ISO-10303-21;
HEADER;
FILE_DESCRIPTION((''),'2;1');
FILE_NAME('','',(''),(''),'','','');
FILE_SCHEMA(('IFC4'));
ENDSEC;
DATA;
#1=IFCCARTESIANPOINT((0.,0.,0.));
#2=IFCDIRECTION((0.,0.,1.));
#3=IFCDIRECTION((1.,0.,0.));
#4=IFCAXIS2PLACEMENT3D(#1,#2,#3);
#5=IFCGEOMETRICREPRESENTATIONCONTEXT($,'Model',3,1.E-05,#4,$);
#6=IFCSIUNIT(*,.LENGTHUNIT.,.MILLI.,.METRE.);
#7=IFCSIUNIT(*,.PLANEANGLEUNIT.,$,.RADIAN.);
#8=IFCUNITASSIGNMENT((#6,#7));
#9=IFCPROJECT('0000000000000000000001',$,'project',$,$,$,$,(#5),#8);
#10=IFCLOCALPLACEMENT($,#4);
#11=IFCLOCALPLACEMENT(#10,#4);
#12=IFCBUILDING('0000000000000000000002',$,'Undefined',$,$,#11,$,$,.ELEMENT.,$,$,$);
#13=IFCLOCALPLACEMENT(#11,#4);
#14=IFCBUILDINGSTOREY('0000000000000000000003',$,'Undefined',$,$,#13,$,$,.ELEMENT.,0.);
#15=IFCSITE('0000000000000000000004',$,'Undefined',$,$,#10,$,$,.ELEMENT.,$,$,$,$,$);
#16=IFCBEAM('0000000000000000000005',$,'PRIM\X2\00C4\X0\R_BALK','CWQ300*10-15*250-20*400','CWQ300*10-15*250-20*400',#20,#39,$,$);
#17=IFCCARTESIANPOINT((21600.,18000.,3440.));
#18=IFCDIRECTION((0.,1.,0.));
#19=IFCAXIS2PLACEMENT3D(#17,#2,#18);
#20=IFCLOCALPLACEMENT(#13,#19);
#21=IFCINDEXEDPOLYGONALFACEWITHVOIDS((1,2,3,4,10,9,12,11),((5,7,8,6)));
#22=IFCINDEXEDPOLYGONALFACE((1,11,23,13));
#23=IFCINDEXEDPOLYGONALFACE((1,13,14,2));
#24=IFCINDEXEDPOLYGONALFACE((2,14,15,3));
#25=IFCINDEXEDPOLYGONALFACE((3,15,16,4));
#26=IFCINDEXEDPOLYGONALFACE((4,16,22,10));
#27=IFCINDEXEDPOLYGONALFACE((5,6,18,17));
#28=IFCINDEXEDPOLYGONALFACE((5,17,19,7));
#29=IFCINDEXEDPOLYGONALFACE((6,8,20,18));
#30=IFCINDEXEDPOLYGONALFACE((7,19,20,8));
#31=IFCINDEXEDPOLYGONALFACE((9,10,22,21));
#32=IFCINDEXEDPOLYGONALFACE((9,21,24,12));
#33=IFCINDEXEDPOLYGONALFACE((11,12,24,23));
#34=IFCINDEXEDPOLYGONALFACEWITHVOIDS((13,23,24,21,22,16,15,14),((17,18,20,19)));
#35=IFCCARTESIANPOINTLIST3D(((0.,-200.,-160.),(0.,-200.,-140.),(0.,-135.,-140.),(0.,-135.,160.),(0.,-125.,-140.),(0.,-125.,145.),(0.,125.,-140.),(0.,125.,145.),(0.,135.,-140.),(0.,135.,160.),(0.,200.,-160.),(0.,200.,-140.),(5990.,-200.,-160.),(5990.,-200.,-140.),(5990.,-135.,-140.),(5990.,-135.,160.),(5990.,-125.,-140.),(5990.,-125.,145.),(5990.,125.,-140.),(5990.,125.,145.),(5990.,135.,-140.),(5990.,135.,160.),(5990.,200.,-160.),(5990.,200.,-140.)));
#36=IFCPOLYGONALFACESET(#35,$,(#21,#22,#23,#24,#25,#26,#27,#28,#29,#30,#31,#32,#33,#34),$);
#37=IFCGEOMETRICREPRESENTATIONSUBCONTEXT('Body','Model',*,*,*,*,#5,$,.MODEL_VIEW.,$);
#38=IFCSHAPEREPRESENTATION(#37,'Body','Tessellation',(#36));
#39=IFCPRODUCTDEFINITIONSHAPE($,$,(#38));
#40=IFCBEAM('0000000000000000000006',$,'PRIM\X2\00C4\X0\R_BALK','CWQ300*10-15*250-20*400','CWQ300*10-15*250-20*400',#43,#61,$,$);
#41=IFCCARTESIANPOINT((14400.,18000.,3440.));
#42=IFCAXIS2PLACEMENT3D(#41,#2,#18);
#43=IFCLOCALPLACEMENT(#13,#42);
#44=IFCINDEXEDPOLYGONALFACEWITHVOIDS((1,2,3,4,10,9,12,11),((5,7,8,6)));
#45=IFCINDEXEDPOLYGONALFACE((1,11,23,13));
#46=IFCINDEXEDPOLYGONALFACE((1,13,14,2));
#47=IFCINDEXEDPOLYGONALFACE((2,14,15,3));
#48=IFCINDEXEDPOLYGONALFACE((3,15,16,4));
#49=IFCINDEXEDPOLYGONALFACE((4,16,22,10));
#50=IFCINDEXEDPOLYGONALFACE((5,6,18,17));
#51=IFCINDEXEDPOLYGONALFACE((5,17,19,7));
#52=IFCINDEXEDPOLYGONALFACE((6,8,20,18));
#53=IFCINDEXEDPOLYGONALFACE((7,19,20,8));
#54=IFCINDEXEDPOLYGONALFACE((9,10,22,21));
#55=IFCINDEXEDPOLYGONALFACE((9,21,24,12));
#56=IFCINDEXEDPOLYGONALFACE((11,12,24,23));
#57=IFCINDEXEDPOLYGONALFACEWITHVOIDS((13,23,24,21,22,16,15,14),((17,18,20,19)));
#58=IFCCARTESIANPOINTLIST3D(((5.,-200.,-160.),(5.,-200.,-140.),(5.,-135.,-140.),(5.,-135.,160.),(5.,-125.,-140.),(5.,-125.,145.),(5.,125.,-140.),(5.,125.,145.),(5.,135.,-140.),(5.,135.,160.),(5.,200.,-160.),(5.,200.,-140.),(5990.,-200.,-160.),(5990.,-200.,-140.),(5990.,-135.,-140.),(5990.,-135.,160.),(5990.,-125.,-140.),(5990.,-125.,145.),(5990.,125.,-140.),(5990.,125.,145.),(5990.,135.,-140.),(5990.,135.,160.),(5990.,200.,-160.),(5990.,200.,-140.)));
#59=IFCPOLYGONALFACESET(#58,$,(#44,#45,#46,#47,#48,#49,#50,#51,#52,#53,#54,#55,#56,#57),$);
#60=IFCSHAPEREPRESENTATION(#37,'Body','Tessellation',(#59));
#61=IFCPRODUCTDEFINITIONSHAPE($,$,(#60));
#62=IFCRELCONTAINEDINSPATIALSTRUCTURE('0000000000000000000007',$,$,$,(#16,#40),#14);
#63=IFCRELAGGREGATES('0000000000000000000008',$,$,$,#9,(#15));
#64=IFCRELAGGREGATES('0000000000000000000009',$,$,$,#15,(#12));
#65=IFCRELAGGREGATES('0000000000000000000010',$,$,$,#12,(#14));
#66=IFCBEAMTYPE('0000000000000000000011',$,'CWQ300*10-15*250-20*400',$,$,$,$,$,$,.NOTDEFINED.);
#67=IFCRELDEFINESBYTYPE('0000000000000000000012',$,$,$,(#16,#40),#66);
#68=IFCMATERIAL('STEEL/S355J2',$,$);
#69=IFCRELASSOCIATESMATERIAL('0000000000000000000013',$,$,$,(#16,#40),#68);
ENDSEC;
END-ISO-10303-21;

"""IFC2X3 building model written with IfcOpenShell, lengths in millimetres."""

from ifc_helpers import new_model, si_unit, frame, origin_with_axes, place, context, subcontext, project, spatial, polyline, outline, extrude, clip, halfspace, material, type_object, element, save


model = new_model("IFC2X3")

# Units and contexts
model_context = context("Model", 3, precision=1e-05, world=origin_with_axes())
body_context = subcontext(model_context, "Body", "Model", "MODEL_VIEW")
ifc_project = project(units=[si_unit("LENGTHUNIT", "METRE", prefix="MILLI"), si_unit("PLANEANGLEUNIT", "RADIAN")], contexts=[model_context])

# Site, building, storey
site_placement = place(None, origin_with_axes())
site = spatial("IfcSite", under=ifc_project, at=site_placement, Name="Undefined", CompositionType="ELEMENT")
building_placement = place(site_placement, origin_with_axes())
building = spatial("IfcBuilding", under=site, at=building_placement, Name="Undefined", CompositionType="ELEMENT")
storey_placement = place(building_placement, origin_with_axes())
storey = spatial("IfcBuildingStorey", under=building, at=storey_placement, Name="Undefined", CompositionType="ELEMENT", Elevation=0.0)

# Shared definitions
ifc_material_1 = material(Name="STEEL/S355J2")

# Beams
beam_type_1 = type_object("IfcBeamType", Name="CWQ300*10-15*250-20*400", PredefinedType="NOTDEFINED")
beam_1_placement = place(storey_placement, frame((21600.0, 18000.0, 3440.0), z_axis=(0.0, 0.0, 1.0), x_axis=(0.0, 1.0, 0.0)))
element("IfcBeam", 1, at=beam_1_placement, inside=storey, type_object=beam_type_1, material=ifc_material_1, Name="PRIMÄR_BALK", Description="CWQ300*10-15*250-20*400", ObjectType="CWQ300*10-15*250-20*400", context=body_context, shape_type="Clipping", body=[
    clip(extrude(outline(polyline([(135.0, 160.0), (135.0, -140.0), (200.0, -140.0), (200.0, -160.0), (-200.0, -160.0), (-200.0, -140.0), (-135.0, -140.0), (-135.0, 160.0), (135.0, 160.0)]), holes=[polyline([(-125.0, -140.0), (125.0, -140.0), (125.0, 145.0), (-125.0, 145.0), (-125.0, -140.0)])]), frame((5990.0, 0.0, 0.0), z_axis=(-1.0, 0.0, 0.0), x_axis=(0.0, -1.0, 0.0)), (0.0, 0.0, 1.0), 5990.0), halfspace(frame((5990.0, 0.0, -160.0), z_axis=(-1.0, 0.0, 0.0), x_axis=(0.0, -1.0, 0.0)), True)),
])
beam_2_placement = place(storey_placement, frame((14400.0, 18000.0, 3440.0), z_axis=(0.0, 0.0, 1.0), x_axis=(0.0, 1.0, 0.0)))
element("IfcBeam", 2, at=beam_2_placement, inside=storey, type_object=beam_type_1, material=ifc_material_1, Name="PRIMÄR_BALK", Description="CWQ300*10-15*250-20*400", ObjectType="CWQ300*10-15*250-20*400", context=body_context, shape_type="Clipping", body=[
    clip(clip(extrude(outline(polyline([(135.0, 160.0), (135.0, -140.0), (200.0, -140.0), (200.0, -160.0), (-200.0, -160.0), (-200.0, -140.0), (-135.0, -140.0), (-135.0, 160.0), (135.0, 160.0)]), holes=[polyline([(-125.0, -140.0), (125.0, -140.0), (125.0, 145.0), (-125.0, 145.0), (-125.0, -140.0)])]), frame((5990.0, 0.0, 0.0), z_axis=(-1.0, 0.0, 0.0), x_axis=(0.0, -1.0, 0.0)), (0.0, 0.0, 1.0), 5985.0), halfspace(frame((5990.0, 0.0, -160.0), z_axis=(-1.0, 0.0, 0.0), x_axis=(0.0, -1.0, 0.0)), True)), halfspace(frame((5.0, 0.0, -160.0), z_axis=(-1.0, 0.0, 0.0), x_axis=(0.0, -1.0, 0.0)), False)),
])

save(model, "model.ifc")
